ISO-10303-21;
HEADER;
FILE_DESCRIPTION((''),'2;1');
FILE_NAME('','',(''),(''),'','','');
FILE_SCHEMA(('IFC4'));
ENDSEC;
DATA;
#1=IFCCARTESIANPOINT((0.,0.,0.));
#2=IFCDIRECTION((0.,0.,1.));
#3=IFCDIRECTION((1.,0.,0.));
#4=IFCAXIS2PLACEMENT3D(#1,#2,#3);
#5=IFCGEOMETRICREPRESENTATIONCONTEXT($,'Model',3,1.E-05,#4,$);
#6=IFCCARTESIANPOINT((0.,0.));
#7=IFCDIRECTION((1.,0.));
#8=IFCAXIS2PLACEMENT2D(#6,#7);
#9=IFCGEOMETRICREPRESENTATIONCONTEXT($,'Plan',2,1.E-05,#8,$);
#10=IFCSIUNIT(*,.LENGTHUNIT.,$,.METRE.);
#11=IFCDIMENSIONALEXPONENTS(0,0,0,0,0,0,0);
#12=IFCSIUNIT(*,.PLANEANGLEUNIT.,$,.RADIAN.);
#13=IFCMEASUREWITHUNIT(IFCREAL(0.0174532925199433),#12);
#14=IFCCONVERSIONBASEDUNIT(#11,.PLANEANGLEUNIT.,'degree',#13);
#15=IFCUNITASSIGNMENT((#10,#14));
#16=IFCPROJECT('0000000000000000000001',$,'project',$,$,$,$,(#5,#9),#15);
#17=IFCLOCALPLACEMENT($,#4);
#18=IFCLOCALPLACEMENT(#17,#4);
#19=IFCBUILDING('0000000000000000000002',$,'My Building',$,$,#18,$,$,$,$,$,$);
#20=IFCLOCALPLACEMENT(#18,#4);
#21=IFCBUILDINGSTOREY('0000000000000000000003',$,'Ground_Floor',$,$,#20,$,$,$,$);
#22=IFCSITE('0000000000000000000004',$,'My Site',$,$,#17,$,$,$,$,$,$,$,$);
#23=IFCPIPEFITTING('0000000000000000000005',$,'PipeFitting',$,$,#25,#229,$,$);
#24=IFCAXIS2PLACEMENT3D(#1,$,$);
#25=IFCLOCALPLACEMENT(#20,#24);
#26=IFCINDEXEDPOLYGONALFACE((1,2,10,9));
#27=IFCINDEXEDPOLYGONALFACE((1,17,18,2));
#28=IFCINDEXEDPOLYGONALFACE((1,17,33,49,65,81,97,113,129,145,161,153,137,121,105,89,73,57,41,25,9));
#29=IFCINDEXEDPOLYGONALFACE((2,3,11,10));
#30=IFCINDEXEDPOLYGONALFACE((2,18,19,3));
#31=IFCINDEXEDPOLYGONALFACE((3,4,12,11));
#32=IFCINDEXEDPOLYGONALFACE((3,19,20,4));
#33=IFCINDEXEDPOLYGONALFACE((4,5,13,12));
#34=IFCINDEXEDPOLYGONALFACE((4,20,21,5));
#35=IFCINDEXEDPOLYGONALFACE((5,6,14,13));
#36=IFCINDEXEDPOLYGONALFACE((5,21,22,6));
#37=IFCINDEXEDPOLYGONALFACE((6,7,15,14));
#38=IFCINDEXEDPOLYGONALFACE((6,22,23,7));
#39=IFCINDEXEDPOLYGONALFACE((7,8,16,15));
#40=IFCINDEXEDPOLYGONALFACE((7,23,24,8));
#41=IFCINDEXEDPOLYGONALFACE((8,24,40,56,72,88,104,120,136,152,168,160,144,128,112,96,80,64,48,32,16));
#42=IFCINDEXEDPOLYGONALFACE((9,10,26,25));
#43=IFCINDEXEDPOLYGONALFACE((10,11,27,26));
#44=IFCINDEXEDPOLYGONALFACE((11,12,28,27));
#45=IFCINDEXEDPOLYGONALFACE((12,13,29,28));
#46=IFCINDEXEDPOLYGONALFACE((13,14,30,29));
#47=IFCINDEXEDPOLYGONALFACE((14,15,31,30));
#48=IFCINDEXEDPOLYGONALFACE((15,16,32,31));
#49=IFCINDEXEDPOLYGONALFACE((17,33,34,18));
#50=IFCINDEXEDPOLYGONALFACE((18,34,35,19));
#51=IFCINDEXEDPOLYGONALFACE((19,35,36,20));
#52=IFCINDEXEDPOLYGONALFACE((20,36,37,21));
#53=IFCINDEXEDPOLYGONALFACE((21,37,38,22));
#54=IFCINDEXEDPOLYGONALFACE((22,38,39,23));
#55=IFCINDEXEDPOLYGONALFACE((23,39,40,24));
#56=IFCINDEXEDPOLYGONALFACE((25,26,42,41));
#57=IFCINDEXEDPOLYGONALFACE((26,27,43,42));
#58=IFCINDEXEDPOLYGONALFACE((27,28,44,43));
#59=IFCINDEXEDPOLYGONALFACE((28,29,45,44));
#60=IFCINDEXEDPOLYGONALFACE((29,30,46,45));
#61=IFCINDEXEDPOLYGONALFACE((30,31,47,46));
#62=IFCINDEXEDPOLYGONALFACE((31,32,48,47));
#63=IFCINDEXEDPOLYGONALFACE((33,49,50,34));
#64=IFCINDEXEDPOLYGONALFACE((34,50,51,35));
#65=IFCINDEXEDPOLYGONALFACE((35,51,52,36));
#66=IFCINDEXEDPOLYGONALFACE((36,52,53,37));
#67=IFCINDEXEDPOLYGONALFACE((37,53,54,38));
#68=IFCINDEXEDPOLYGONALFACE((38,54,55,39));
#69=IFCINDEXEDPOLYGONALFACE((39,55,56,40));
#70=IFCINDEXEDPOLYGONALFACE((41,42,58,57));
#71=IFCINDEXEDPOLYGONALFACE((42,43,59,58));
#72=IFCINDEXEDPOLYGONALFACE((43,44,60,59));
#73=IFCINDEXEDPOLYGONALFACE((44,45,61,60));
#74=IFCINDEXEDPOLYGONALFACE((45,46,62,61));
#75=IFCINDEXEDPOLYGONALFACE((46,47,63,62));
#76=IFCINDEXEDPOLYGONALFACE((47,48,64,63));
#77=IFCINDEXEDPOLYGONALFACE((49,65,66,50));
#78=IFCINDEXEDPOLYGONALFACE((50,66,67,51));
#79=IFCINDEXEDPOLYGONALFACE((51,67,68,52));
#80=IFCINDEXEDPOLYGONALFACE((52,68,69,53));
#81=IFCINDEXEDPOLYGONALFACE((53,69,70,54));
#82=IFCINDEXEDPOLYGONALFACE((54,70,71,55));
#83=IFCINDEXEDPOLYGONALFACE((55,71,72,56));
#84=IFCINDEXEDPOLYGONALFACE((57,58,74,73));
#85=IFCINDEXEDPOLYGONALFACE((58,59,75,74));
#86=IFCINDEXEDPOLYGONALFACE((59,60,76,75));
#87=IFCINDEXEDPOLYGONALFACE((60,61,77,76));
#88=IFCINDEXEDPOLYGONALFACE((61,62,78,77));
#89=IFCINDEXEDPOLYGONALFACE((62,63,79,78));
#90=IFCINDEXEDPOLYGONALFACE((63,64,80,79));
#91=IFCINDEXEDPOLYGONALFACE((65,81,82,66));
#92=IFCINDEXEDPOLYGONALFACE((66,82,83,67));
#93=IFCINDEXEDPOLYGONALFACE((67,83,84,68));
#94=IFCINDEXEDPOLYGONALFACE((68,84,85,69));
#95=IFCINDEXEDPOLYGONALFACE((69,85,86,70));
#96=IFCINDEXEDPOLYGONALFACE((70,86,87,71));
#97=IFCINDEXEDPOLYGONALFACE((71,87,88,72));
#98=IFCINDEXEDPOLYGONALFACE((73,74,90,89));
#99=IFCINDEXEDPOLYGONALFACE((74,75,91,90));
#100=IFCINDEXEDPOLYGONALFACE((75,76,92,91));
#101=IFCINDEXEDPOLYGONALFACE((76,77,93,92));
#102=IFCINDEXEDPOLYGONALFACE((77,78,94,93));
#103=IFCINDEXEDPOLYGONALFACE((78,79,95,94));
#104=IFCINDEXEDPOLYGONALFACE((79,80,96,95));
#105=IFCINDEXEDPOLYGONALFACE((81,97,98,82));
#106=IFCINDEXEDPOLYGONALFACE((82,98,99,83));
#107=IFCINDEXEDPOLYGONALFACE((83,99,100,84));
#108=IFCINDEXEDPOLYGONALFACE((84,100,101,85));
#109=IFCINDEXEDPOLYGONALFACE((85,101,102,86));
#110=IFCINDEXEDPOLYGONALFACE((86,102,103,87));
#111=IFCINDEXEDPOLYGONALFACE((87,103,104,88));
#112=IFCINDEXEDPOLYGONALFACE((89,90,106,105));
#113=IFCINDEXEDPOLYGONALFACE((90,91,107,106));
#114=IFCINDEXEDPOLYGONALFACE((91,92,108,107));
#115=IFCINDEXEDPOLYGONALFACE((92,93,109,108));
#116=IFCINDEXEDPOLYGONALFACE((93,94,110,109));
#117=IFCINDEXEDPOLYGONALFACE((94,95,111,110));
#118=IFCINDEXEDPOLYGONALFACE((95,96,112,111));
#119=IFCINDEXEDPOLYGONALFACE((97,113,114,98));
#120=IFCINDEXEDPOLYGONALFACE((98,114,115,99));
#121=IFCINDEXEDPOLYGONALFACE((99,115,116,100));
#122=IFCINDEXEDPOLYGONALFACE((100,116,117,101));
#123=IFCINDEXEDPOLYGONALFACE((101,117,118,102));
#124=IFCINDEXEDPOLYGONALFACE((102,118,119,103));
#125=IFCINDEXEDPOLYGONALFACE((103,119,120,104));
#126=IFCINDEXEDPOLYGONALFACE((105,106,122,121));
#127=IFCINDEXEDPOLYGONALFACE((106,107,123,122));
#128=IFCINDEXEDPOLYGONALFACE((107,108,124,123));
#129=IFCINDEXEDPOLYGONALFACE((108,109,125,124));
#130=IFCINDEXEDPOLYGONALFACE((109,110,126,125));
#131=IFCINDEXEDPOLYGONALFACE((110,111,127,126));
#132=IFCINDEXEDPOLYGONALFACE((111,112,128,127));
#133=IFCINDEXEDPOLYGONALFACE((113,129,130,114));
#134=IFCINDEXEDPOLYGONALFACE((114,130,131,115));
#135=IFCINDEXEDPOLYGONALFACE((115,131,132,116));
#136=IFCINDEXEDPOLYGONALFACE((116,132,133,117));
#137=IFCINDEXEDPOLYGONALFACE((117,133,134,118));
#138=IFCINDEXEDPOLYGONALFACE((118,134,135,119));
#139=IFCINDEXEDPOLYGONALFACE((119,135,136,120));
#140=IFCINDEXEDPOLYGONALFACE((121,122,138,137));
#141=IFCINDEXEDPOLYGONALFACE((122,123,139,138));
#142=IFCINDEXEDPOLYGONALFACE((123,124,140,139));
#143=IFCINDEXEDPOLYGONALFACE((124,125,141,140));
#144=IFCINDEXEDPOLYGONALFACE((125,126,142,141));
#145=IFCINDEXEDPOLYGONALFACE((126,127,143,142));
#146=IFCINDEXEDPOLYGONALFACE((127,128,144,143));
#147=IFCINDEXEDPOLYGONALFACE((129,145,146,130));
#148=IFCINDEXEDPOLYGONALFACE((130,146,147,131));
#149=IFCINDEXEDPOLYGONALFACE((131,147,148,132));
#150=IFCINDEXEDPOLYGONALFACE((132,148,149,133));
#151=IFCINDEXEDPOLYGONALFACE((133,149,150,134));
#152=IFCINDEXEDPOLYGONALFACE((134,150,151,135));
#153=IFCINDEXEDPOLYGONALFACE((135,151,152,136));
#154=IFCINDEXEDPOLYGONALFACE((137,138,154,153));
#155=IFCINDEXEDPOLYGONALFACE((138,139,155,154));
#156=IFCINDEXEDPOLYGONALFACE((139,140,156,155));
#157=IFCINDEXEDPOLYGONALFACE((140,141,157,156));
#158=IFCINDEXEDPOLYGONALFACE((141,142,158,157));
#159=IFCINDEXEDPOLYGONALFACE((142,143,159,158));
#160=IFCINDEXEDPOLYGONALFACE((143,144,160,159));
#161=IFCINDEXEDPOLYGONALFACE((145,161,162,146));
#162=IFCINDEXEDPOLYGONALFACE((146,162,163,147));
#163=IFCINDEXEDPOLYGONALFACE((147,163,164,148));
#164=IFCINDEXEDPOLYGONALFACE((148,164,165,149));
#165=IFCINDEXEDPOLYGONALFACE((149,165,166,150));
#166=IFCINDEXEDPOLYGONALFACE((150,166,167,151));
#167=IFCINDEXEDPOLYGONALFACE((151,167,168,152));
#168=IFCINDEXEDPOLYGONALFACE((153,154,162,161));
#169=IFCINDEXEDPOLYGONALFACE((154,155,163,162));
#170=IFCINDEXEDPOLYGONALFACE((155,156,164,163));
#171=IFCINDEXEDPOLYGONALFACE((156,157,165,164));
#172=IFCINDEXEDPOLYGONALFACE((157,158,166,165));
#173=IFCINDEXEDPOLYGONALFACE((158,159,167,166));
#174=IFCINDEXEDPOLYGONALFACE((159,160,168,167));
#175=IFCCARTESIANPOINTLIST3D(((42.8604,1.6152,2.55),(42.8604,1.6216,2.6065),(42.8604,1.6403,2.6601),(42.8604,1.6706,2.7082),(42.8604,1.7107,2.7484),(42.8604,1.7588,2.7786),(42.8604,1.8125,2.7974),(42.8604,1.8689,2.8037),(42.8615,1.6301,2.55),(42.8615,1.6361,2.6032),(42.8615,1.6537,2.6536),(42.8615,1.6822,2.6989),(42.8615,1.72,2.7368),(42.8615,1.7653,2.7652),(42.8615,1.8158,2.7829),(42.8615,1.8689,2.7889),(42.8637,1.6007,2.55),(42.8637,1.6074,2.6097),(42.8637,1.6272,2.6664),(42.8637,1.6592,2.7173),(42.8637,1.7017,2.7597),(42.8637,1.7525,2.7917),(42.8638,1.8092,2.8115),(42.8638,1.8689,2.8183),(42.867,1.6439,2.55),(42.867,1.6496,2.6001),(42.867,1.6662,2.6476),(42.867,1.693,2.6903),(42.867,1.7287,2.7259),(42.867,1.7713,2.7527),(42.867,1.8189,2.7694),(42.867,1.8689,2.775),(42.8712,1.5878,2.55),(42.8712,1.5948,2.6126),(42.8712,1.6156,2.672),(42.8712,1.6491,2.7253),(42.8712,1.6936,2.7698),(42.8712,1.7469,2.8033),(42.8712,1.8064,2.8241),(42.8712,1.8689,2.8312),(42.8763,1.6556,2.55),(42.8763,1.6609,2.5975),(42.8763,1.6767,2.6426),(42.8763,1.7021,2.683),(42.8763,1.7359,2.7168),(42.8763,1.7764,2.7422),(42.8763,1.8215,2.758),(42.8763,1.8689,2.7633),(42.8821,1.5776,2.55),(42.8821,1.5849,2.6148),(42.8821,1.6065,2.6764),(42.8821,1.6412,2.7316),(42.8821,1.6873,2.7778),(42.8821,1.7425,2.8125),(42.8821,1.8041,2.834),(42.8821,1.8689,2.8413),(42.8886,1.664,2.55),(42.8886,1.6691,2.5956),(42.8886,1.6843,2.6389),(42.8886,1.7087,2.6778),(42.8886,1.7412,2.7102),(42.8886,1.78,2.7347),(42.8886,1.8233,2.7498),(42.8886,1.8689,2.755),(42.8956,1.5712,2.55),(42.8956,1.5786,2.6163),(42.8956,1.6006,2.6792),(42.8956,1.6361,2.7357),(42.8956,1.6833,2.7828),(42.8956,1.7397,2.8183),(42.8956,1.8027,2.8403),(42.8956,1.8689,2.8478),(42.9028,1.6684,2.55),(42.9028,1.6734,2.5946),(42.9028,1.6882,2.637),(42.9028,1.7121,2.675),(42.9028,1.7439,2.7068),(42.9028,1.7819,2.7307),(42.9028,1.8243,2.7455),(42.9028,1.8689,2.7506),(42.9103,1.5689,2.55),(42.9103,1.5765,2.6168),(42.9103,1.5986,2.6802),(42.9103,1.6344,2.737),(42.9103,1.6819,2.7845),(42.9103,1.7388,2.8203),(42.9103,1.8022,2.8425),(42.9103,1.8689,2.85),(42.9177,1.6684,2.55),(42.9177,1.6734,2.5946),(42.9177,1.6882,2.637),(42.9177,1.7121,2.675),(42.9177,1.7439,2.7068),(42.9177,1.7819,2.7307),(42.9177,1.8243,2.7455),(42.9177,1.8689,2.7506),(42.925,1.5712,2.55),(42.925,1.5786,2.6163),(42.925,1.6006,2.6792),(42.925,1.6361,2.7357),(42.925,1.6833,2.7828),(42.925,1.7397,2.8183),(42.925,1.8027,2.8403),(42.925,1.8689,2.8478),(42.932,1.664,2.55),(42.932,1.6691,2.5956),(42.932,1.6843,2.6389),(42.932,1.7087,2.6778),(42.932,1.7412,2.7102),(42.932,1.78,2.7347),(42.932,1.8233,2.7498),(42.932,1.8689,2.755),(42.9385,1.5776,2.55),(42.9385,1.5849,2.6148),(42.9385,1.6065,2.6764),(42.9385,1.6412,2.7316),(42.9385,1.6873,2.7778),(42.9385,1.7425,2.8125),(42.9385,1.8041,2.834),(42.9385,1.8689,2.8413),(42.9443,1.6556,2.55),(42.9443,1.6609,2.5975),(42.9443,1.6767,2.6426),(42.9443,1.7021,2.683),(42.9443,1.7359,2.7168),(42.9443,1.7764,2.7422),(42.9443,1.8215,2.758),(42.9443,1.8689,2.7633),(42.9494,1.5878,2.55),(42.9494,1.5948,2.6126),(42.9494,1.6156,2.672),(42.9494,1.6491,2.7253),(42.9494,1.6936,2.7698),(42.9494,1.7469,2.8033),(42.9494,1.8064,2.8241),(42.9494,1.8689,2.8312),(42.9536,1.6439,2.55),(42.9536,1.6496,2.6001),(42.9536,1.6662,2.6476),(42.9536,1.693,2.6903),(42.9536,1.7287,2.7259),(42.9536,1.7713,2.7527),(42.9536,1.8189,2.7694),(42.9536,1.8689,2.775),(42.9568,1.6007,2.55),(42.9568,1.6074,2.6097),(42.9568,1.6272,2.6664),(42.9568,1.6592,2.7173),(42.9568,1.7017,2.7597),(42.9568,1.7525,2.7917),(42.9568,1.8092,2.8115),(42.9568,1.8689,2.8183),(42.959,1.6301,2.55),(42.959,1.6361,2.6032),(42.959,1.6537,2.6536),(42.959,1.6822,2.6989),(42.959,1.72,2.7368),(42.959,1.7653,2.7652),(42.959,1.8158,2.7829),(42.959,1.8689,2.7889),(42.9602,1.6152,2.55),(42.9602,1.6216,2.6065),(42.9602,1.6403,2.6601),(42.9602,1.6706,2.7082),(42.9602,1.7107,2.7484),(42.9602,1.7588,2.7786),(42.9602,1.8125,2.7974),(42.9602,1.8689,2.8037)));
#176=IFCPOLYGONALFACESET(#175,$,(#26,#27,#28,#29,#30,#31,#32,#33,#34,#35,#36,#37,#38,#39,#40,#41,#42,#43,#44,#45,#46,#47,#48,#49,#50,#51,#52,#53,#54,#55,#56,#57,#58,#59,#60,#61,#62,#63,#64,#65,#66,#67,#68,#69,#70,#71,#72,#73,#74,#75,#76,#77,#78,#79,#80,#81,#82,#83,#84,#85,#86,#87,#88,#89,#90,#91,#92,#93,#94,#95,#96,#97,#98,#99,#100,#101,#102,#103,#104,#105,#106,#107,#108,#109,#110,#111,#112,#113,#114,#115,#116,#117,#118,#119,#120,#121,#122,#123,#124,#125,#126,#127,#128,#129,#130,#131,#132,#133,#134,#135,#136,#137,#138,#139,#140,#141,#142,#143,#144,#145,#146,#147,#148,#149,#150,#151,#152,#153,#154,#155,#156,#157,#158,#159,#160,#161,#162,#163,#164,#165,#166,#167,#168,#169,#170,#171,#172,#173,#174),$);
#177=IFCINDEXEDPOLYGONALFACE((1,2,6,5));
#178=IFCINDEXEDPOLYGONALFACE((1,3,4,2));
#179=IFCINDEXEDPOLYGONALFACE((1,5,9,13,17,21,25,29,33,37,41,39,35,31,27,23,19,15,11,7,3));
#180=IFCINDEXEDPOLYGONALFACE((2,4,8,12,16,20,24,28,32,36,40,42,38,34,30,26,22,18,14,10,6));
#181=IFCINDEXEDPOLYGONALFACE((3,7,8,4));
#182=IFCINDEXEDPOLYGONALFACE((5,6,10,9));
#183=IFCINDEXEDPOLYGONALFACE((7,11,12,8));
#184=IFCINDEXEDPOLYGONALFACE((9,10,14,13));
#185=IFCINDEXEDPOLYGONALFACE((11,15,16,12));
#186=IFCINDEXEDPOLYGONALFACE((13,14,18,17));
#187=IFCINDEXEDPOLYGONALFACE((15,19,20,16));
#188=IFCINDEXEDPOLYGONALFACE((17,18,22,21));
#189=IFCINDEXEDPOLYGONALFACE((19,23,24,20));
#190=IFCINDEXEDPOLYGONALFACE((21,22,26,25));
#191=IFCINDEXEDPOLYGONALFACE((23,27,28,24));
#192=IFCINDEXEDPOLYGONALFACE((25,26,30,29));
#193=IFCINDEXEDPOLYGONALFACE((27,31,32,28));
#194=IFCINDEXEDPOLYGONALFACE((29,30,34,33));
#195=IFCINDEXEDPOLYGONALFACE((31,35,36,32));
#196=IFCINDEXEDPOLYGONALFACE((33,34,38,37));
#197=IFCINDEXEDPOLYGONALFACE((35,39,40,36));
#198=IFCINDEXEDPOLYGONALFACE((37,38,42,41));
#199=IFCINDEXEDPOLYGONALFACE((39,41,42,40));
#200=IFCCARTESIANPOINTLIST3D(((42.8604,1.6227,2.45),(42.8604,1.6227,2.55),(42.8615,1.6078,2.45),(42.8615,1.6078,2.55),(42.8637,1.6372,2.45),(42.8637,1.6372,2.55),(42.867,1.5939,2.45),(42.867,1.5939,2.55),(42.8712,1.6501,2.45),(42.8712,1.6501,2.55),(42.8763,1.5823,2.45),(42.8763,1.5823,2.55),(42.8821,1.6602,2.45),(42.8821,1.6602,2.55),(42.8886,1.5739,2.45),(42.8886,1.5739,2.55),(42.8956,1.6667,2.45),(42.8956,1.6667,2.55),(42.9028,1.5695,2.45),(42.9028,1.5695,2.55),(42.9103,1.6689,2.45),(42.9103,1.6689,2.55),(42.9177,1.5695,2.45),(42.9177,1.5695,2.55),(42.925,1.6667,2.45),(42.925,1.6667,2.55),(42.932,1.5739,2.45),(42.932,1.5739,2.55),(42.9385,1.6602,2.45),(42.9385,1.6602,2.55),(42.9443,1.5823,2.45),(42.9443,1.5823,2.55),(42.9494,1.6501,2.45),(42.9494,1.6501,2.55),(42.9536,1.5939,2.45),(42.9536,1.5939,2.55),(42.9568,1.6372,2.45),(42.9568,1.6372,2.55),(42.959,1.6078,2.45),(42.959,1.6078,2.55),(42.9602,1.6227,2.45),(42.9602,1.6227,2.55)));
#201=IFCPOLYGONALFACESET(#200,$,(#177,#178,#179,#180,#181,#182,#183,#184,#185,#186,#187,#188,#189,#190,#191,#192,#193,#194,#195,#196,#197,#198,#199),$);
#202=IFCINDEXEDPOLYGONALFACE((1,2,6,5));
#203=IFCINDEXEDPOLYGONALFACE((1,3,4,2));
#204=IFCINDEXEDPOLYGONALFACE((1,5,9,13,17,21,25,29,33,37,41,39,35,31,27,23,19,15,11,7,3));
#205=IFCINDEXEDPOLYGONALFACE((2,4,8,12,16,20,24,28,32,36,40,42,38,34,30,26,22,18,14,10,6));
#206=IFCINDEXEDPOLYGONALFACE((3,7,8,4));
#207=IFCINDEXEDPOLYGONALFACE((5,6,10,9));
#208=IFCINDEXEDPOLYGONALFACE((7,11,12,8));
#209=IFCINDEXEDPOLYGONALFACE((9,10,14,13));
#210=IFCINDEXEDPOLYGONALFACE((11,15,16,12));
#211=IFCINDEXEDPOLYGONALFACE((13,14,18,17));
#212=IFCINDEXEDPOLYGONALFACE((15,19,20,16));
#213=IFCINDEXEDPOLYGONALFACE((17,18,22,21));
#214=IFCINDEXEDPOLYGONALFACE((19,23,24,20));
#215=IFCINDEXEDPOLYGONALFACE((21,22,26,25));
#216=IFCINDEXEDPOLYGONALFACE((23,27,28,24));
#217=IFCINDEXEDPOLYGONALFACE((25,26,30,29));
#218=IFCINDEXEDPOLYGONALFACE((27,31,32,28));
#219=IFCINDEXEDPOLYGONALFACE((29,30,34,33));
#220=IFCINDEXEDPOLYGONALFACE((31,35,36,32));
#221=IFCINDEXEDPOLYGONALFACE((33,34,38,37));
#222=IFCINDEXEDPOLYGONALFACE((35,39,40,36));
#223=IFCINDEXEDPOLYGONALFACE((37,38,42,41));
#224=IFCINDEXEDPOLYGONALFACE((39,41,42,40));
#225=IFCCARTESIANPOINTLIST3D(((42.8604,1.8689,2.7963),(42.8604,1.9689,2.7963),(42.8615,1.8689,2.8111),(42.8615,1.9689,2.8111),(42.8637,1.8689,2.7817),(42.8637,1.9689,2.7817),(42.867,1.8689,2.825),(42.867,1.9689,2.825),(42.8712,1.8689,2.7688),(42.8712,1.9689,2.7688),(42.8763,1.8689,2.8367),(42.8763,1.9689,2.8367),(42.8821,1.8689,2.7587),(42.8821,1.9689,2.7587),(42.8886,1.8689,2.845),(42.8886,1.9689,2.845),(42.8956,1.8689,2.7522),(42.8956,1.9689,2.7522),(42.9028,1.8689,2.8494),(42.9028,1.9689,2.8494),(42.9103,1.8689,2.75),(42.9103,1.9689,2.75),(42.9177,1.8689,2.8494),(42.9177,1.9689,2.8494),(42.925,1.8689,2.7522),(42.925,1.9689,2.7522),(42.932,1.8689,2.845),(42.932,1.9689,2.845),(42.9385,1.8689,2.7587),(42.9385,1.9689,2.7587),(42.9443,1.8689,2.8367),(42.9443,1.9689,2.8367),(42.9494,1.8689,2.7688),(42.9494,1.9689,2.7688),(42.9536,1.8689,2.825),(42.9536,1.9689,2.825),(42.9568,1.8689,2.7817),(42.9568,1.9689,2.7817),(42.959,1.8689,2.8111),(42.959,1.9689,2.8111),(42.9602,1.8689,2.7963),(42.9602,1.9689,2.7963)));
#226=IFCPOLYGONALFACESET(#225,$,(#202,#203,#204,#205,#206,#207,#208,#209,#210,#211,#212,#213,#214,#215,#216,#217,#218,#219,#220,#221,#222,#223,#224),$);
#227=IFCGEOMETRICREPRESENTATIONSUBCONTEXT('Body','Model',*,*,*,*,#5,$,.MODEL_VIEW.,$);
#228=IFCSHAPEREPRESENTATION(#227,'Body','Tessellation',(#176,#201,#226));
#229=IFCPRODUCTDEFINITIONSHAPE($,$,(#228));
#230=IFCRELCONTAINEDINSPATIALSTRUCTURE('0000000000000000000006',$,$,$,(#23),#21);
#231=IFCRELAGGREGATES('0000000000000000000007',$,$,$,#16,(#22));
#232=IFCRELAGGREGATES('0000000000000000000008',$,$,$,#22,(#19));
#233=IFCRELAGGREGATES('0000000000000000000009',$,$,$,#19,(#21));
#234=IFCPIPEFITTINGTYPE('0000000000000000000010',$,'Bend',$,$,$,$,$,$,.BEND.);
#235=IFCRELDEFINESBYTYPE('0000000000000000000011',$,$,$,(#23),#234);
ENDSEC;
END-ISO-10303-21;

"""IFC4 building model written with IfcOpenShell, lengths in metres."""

from ifc_helpers import new_model, entity, si_unit, converted_unit, frame, origin_with_axes, origin_2d_with_axis, place, context, subcontext, project, spatial, circle, extrude, source, transform, mapped, type_object, type_shapes, element, save


model = new_model("IFC4")

# Units and contexts
model_context = context("Model", 3, precision=1e-05, world=origin_with_axes())
plan_context = context("Plan", 2, precision=1e-05, world=origin_2d_with_axis())
body_context = subcontext(model_context, "Body", "Model", "MODEL_VIEW")
ifc_project = project(units=[si_unit("LENGTHUNIT", "METRE"), converted_unit("PLANEANGLEUNIT", "degree", entity("IfcReal", 0.0174532925199433), si_unit("PLANEANGLEUNIT", "RADIAN"), dimensions=[0, 0, 0, 0, 0, 0, 0])], contexts=[model_context, plan_context])

# Site, building, storey
site_placement = place(None, origin_with_axes())
site = spatial("IfcSite", under=ifc_project, at=site_placement, Name="My Site")
building_placement = place(site_placement, origin_with_axes())
building = spatial("IfcBuilding", under=site, at=building_placement, Name="My Building")
storey_placement = place(building_placement, origin_with_axes())
storey = spatial("IfcBuildingStorey", under=building, at=storey_placement, Name="Ground_Floor")

# Pipe fitting
pipe_fitting_type = type_object("IfcPipeFittingType", Name="Bend", PredefinedType="BEND")
shared_shape_1 = source(origin_with_axes(), body_context, "Body", "SolidModel", [
    entity("IfcSweptDiskSolid", entity("IfcIndexedPolyCurve", entity("IfcCartesianPointList3D", [[0.0, 0.0, -0.1], [0.0732, 0.0, -0.2768], [0.25, 0.0, -0.35]]), [entity("IfcArcIndex", [1, 2, 3])]), 0.05),
    extrude(circle(Radius=0.05), origin_with_axes(), (0.0, 0.0, -1.0), 0.1),
    extrude(circle(Radius=0.05), frame((0.25, 0.0, -0.35), z_axis=(1.0, 0.0, 0.0), x_axis=(0.0, 0.0, 1.0)), (0.0, 0.0, 1.0), 0.1),
])
type_shapes(pipe_fitting_type, [shared_shape_1])
for number, where, z_axis, x_axis, name in (
    (1, (42.9103, 1.6189, 2.45), (0.0, 0.0, -1.0), (0.0, 1.0, 0.0), "PipeFitting"),
):
    element("IfcPipeFitting", number, at=place(storey_placement, frame(where, z_axis=z_axis, x_axis=x_axis)), inside=storey, type_object=pipe_fitting_type, Name=name, context=body_context, shape_type="MappedRepresentation", body=[
        mapped(shared_shape_1, transform((0.0, 0.0, 0.0), x_axis=(1.0, 0.0, 0.0), y_axis=(0.0, 1.0, 0.0), z_axis=(0.0, 0.0, 1.0), scale=1.0)),
    ])

save(model, "model.ifc")
